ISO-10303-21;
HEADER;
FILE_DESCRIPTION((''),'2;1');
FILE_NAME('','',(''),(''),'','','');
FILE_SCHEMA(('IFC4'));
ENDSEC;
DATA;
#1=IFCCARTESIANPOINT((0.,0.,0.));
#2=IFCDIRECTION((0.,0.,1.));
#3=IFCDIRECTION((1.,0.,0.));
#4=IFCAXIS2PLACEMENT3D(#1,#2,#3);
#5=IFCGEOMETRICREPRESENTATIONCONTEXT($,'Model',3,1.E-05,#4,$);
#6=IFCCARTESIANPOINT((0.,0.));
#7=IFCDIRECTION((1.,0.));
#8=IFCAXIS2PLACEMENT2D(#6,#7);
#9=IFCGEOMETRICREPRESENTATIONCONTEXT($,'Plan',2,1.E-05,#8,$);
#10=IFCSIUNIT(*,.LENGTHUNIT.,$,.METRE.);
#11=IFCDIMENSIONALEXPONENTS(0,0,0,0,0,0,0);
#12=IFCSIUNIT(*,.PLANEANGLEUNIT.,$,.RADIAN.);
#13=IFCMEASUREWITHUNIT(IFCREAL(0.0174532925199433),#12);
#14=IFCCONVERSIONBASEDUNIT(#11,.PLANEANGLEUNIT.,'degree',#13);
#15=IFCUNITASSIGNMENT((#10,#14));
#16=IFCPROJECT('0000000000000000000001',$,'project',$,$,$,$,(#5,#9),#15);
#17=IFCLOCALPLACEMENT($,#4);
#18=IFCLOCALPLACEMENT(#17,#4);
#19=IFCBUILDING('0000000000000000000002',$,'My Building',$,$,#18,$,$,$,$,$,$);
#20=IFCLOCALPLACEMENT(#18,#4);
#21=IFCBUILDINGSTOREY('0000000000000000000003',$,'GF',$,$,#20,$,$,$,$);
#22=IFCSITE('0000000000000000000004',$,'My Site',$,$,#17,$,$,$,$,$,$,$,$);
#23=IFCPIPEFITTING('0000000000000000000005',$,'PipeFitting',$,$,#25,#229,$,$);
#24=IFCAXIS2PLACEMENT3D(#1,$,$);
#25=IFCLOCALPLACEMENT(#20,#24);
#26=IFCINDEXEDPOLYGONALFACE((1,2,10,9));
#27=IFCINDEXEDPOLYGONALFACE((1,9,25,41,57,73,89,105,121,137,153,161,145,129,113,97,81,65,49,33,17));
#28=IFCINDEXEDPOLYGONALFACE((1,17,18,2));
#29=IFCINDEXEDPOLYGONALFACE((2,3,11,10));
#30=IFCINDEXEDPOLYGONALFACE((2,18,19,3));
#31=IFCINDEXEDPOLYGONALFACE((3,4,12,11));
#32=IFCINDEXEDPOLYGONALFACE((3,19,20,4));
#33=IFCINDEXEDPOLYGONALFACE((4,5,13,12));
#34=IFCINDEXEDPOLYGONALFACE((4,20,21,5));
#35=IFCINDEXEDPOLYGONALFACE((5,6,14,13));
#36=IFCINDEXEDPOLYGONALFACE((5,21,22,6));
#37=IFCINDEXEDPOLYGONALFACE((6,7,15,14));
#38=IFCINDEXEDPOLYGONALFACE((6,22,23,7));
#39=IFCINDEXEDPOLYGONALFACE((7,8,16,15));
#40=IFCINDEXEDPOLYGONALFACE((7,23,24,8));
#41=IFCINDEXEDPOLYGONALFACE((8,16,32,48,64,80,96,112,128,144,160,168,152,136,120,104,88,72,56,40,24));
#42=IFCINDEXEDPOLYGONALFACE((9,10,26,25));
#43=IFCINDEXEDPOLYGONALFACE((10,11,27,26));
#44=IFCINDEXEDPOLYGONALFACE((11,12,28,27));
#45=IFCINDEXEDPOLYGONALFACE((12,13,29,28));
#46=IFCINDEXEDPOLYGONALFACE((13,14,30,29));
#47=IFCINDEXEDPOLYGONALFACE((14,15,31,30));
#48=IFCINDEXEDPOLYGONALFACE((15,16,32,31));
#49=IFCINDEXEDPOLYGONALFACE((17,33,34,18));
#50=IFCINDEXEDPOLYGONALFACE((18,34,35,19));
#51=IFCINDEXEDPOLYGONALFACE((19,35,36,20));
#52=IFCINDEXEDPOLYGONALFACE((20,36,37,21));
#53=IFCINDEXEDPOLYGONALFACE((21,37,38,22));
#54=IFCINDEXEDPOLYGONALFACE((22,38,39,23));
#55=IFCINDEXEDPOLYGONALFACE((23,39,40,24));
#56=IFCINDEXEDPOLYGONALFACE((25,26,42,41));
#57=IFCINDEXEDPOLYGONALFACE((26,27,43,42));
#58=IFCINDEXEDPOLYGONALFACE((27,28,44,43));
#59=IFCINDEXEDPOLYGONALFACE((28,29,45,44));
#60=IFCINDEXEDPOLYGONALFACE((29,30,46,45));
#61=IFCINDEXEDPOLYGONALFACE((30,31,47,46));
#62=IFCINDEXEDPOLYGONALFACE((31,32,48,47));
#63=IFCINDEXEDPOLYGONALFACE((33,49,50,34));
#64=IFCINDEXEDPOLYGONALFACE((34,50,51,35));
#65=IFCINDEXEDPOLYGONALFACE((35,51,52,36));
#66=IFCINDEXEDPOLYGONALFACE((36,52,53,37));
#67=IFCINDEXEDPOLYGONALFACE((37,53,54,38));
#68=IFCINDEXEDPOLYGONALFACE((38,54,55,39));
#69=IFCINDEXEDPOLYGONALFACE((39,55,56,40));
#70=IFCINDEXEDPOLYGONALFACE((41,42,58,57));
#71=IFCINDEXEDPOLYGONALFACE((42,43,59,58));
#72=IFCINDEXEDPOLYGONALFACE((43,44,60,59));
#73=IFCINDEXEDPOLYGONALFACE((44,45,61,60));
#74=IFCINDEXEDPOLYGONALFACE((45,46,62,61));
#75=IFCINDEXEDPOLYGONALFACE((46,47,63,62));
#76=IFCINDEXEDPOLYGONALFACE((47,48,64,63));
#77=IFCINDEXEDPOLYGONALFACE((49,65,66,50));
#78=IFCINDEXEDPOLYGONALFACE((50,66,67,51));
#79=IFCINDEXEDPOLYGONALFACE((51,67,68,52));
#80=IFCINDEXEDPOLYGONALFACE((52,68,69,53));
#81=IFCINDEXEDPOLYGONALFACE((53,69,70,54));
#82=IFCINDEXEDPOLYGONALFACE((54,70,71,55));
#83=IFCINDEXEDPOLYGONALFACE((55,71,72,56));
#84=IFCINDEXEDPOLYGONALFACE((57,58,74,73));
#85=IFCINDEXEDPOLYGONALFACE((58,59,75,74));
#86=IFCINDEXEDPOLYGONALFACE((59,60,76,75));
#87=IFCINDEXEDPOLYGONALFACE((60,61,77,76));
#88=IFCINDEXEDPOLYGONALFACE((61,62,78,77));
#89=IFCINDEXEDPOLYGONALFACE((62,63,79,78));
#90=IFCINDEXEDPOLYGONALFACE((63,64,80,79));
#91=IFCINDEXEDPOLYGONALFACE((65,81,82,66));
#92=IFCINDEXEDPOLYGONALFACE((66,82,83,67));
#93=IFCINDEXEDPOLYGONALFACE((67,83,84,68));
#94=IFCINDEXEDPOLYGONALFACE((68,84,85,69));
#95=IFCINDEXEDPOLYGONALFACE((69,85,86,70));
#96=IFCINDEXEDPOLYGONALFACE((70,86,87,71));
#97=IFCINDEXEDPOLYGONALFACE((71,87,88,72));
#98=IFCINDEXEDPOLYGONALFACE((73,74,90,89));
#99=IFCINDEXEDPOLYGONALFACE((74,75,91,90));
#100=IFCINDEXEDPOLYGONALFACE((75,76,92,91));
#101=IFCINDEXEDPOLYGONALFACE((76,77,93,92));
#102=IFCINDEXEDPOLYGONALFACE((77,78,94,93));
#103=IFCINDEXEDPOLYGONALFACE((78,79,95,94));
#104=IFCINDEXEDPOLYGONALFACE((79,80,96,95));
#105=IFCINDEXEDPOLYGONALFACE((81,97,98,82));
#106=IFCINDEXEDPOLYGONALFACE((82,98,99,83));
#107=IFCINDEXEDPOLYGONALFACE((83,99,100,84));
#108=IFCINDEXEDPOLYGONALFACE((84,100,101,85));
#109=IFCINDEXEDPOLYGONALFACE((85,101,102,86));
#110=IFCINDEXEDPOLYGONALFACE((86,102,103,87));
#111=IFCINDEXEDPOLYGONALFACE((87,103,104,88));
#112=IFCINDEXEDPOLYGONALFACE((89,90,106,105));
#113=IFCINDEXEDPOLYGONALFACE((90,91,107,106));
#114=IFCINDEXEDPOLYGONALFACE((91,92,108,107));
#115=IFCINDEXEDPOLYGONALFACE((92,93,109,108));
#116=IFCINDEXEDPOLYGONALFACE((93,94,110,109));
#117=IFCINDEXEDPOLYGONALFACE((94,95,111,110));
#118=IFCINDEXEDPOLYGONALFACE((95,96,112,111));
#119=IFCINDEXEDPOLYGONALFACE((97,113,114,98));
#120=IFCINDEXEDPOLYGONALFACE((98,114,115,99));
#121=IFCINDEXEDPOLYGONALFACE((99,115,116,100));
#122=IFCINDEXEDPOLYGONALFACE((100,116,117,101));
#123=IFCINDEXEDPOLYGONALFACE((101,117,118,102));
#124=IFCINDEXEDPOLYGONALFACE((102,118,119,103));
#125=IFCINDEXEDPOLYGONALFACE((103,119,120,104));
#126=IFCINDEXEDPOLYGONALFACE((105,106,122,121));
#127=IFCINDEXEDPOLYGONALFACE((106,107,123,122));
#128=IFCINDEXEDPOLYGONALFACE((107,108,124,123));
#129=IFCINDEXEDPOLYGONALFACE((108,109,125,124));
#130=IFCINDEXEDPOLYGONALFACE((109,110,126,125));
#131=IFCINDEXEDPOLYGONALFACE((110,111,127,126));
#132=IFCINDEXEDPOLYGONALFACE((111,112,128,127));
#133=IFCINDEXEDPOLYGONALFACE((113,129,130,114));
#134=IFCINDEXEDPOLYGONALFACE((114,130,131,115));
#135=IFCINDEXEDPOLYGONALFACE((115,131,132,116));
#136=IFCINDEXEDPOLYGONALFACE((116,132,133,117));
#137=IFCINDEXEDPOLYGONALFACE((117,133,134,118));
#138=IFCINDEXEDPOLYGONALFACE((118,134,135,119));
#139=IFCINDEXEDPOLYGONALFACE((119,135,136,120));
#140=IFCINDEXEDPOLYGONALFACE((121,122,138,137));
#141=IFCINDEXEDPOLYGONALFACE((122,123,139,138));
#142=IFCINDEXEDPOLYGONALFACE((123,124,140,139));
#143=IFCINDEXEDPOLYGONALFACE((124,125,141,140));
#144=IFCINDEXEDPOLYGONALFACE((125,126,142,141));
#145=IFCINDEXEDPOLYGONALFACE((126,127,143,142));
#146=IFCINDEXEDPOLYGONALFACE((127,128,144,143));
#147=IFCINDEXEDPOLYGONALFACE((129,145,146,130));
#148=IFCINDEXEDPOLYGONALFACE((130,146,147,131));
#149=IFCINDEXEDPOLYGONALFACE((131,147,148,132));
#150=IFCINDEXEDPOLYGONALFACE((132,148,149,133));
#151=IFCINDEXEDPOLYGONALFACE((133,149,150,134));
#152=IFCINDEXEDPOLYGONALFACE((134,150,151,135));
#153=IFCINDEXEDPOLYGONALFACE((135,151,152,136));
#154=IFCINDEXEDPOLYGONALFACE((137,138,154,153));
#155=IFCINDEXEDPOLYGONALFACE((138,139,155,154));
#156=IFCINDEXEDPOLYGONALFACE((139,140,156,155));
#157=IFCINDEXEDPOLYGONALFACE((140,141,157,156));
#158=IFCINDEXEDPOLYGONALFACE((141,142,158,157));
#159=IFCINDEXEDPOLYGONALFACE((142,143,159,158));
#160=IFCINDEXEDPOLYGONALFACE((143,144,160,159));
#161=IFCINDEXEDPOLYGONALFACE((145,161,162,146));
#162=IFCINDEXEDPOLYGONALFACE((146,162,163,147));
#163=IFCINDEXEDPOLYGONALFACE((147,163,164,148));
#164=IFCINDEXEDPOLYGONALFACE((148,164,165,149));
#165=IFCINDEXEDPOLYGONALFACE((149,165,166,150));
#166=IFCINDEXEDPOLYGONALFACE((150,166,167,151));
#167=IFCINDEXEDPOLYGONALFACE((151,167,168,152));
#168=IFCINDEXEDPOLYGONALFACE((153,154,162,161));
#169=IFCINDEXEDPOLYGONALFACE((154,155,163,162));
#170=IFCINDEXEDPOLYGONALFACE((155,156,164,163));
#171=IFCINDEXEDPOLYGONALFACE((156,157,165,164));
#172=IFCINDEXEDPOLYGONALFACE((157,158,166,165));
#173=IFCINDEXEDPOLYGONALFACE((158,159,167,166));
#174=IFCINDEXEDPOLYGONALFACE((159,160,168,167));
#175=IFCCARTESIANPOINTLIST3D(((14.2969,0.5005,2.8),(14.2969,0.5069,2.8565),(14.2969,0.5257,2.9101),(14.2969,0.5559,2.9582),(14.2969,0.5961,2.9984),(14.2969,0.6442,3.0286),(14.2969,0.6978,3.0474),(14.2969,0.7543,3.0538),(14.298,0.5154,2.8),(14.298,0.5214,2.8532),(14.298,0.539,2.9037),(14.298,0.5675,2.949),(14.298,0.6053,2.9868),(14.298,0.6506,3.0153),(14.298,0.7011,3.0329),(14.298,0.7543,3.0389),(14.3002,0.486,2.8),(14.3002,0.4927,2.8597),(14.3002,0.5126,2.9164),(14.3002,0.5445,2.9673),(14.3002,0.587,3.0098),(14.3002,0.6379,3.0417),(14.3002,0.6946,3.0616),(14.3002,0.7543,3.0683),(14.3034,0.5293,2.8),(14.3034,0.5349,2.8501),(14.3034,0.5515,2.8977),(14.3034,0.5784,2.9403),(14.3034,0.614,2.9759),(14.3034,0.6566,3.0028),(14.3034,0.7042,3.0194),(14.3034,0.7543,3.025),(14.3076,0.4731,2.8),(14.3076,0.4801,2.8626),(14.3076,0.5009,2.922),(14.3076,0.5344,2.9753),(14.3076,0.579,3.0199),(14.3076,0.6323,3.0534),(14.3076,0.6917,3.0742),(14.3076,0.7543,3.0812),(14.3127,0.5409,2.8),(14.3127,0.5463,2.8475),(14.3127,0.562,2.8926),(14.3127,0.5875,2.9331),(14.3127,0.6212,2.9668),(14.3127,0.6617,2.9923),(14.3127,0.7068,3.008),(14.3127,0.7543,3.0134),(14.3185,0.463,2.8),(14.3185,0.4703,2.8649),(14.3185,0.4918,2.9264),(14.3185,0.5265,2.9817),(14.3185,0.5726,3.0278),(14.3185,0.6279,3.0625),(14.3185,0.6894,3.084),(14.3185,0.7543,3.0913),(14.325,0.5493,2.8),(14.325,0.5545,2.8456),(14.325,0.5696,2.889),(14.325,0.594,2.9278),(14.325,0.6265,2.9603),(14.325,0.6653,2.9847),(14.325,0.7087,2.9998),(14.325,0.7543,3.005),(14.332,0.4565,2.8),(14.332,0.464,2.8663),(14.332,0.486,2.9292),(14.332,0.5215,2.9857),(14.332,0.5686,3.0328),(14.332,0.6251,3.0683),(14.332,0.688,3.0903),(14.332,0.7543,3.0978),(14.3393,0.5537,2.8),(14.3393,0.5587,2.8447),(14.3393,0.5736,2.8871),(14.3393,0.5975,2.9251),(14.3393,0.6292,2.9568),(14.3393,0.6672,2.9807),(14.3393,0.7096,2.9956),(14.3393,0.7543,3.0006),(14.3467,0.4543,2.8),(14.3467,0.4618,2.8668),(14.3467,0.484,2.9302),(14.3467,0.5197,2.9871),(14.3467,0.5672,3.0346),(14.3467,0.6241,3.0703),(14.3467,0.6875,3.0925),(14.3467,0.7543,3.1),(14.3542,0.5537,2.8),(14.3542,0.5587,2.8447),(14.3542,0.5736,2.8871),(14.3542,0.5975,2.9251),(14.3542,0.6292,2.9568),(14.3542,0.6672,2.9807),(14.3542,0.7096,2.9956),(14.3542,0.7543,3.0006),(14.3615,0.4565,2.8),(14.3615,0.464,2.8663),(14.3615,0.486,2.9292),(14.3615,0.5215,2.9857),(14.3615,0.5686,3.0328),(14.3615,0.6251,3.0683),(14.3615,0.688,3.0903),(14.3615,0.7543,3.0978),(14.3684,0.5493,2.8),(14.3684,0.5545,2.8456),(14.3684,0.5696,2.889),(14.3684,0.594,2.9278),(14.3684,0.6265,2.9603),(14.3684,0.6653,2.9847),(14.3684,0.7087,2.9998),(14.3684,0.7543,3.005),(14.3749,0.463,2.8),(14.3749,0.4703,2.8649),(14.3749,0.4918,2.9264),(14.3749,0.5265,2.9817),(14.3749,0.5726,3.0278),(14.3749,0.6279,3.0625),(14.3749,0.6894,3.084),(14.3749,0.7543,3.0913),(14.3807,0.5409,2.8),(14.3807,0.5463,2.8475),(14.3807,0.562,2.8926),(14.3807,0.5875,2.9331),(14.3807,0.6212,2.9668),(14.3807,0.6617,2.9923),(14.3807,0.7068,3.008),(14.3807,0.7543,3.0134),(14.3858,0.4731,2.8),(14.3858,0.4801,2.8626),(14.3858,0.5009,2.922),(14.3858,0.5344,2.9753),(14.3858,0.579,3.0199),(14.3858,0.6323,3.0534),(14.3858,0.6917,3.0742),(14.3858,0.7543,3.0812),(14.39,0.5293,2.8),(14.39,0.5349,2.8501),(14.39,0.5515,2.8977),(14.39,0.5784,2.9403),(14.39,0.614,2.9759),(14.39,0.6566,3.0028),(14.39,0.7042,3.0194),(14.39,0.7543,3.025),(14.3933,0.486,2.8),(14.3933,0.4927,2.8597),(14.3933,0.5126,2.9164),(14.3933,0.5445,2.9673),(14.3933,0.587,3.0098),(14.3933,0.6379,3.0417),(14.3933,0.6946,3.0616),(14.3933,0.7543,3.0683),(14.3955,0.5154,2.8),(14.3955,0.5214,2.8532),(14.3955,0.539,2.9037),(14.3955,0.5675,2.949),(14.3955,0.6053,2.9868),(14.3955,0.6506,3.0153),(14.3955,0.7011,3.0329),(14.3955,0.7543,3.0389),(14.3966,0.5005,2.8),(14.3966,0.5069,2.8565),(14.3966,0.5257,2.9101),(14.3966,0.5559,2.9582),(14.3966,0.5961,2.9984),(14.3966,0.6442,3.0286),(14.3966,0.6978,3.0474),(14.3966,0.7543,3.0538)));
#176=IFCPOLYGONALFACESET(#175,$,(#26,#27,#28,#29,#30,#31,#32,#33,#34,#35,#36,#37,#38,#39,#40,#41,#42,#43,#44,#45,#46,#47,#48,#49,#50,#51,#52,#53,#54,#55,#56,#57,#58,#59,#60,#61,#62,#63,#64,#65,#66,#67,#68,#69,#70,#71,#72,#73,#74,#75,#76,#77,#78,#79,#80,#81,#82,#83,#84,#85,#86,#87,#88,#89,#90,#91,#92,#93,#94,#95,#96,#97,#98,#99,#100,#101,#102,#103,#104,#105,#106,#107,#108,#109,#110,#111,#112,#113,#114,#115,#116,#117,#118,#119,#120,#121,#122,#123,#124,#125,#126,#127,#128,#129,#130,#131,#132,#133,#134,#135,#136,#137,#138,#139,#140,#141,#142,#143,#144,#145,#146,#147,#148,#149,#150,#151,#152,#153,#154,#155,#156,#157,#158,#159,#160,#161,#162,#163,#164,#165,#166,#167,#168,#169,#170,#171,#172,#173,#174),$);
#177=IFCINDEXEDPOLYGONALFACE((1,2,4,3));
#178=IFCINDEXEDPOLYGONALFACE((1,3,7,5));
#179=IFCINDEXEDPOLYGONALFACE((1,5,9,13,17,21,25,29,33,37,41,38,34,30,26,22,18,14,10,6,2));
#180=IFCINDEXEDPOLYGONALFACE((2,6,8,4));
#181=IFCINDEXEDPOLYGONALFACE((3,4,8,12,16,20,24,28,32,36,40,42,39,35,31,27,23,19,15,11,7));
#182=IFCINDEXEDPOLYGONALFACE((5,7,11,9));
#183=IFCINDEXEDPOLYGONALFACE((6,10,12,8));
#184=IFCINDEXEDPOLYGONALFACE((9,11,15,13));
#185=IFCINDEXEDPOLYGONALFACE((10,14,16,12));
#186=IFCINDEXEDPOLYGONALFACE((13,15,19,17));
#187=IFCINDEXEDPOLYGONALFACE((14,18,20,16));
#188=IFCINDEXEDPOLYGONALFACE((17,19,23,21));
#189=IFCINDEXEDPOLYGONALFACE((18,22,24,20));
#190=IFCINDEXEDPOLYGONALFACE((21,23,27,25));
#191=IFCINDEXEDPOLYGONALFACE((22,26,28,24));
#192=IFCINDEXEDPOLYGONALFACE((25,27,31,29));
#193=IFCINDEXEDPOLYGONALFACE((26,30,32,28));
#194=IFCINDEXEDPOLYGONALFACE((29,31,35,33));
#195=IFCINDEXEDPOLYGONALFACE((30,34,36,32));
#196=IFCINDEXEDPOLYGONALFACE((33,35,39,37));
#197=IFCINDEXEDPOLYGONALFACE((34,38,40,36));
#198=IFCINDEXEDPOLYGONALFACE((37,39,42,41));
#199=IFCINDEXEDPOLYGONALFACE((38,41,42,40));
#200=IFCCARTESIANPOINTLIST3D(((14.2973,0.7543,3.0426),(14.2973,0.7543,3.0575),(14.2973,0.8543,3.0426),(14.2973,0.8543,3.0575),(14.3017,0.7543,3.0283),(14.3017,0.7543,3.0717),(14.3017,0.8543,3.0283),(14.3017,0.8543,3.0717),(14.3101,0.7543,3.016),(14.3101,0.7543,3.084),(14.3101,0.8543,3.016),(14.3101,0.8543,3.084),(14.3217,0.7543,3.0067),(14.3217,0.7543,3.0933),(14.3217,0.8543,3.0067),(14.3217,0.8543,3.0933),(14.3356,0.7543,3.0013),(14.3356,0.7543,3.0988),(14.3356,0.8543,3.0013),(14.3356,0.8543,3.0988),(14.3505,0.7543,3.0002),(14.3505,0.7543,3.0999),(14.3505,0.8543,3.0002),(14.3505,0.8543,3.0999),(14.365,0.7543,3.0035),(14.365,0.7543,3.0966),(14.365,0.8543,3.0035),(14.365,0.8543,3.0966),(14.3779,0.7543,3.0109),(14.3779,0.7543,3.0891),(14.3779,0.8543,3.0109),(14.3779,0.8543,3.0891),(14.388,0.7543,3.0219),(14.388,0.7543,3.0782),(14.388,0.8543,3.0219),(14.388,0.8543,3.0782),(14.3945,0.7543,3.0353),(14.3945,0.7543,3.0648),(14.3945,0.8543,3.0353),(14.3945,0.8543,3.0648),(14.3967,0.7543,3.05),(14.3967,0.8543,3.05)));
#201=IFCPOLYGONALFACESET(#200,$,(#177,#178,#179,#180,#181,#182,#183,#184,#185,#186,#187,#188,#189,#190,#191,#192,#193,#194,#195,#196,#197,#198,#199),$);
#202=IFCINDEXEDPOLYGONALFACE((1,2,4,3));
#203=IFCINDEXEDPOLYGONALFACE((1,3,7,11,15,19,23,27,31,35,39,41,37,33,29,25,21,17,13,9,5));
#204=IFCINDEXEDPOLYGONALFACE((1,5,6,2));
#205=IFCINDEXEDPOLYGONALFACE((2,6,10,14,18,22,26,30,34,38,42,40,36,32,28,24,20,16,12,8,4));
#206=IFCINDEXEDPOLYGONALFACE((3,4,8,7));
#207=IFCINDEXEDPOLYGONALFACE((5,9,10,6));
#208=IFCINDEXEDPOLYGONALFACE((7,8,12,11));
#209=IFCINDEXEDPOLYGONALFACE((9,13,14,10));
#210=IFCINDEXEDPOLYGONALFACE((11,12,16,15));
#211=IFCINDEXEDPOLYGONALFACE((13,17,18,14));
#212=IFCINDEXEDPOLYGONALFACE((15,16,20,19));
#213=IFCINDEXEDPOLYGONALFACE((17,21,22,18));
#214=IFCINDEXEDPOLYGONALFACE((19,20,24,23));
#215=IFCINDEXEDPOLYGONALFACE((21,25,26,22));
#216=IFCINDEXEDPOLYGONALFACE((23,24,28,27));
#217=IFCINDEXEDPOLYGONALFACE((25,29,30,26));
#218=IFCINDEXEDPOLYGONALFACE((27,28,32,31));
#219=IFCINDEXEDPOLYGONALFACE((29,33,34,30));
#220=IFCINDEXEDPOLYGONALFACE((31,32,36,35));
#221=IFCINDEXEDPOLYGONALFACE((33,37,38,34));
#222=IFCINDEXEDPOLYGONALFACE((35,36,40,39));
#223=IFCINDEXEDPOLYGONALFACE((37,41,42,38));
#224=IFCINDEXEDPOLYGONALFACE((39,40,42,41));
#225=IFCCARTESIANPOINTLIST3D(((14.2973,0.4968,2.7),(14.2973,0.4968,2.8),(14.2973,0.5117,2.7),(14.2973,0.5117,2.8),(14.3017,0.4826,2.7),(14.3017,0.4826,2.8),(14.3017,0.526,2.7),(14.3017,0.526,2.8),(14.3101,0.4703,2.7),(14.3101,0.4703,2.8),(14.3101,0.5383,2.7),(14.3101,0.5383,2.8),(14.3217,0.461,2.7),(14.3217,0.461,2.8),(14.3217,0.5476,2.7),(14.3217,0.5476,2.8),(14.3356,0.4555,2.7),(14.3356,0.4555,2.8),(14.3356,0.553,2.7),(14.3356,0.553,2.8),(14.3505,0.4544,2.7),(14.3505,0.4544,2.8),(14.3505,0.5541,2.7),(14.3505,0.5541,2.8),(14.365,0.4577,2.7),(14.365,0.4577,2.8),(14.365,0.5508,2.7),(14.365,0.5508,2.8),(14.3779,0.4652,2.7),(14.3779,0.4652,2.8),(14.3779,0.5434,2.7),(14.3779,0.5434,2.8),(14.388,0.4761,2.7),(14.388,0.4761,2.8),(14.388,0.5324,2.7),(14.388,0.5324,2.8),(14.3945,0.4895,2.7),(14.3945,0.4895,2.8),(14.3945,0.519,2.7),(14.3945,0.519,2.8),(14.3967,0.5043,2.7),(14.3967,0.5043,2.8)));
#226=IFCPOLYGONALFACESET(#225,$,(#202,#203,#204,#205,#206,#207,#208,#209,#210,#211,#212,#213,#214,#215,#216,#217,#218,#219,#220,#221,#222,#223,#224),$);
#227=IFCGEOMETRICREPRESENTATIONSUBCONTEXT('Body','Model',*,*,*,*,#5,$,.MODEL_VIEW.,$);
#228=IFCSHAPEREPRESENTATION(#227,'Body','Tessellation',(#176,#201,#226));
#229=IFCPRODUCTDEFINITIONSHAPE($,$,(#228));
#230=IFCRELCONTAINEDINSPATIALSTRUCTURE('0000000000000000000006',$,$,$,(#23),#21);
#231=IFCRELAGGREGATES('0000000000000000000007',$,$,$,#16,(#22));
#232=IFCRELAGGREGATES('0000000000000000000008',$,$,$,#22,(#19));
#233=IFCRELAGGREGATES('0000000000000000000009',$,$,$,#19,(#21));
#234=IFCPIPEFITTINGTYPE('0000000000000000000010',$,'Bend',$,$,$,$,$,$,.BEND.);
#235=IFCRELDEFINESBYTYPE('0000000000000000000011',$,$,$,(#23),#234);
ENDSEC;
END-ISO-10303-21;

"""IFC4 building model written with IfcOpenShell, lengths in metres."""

from ifc_helpers import new_model, entity, si_unit, converted_unit, frame, origin_with_axes, origin_2d_with_axis, place, context, subcontext, project, spatial, circle, extrude, source, transform, mapped, type_object, type_shapes, element, save


model = new_model("IFC4")

# Units and contexts
model_context = context("Model", 3, precision=1e-05, world=origin_with_axes())
plan_context = context("Plan", 2, precision=1e-05, world=origin_2d_with_axis())
body_context_1 = subcontext(model_context, "Body", "Model", "MODEL_VIEW")
ifc_project = project(units=[si_unit("LENGTHUNIT", "METRE"), converted_unit("PLANEANGLEUNIT", "degree", entity("IfcReal", 0.0174532925199433), si_unit("PLANEANGLEUNIT", "RADIAN"), dimensions=[0, 0, 0, 0, 0, 0, 0])], contexts=[model_context, plan_context])

# Site, building, storey
site_placement = place(None, origin_with_axes())
site = spatial("IfcSite", under=ifc_project, at=site_placement, Name="My Site")
building_placement = place(site_placement, origin_with_axes())
building = spatial("IfcBuilding", under=site, at=building_placement, Name="My Building")
storey_placement = place(building_placement, origin_with_axes())
storey = spatial("IfcBuildingStorey", under=building, at=storey_placement, Name="GF")

# Pipe fitting
pipe_fitting_type = type_object("IfcPipeFittingType", Name="Bend", PredefinedType="BEND")
shared_shape_1 = source(origin_with_axes(), body_context_1, "Body", "SolidModel", [
    entity("IfcSweptDiskSolid", entity("IfcIndexedPolyCurve", entity("IfcCartesianPointList3D", [[0.0, 0.0, 0.1], [0.0, -0.0732, 0.2768], [0.0, -0.25, 0.35]]), [entity("IfcArcIndex", [1, 2, 3])]), 0.05),
    extrude(circle(Radius=0.05), origin_with_axes(), (0.0, 0.0, 1.0), 0.1),
    extrude(circle(Radius=0.05), frame((0.0, -0.25, 0.35), z_axis=(0.0, -1.0, 0.0), x_axis=(1.0, 0.0, 0.0)), (0.0, 0.0, 1.0), 0.1),
])
type_shapes(pipe_fitting_type, [shared_shape_1])
for number, where, z_axis, x_axis, name in (
    (1, (14.3467, 0.8543, 3.05), (0.0, -1.0, 0.0), (1.0, 0.0, 0.0), "PipeFitting"),
):
    element("IfcPipeFitting", number, at=place(storey_placement, frame(where, z_axis=z_axis, x_axis=x_axis)), inside=storey, type_object=pipe_fitting_type, Name=name, context=body_context_1, shape_type="MappedRepresentation", body=[
        mapped(shared_shape_1, transform((0.0, 0.0, 0.0), x_axis=(1.0, 0.0, 0.0), y_axis=(0.0, 1.0, 0.0), z_axis=(0.0, 0.0, 1.0), scale=1.0)),
    ])

save(model, "model.ifc")
